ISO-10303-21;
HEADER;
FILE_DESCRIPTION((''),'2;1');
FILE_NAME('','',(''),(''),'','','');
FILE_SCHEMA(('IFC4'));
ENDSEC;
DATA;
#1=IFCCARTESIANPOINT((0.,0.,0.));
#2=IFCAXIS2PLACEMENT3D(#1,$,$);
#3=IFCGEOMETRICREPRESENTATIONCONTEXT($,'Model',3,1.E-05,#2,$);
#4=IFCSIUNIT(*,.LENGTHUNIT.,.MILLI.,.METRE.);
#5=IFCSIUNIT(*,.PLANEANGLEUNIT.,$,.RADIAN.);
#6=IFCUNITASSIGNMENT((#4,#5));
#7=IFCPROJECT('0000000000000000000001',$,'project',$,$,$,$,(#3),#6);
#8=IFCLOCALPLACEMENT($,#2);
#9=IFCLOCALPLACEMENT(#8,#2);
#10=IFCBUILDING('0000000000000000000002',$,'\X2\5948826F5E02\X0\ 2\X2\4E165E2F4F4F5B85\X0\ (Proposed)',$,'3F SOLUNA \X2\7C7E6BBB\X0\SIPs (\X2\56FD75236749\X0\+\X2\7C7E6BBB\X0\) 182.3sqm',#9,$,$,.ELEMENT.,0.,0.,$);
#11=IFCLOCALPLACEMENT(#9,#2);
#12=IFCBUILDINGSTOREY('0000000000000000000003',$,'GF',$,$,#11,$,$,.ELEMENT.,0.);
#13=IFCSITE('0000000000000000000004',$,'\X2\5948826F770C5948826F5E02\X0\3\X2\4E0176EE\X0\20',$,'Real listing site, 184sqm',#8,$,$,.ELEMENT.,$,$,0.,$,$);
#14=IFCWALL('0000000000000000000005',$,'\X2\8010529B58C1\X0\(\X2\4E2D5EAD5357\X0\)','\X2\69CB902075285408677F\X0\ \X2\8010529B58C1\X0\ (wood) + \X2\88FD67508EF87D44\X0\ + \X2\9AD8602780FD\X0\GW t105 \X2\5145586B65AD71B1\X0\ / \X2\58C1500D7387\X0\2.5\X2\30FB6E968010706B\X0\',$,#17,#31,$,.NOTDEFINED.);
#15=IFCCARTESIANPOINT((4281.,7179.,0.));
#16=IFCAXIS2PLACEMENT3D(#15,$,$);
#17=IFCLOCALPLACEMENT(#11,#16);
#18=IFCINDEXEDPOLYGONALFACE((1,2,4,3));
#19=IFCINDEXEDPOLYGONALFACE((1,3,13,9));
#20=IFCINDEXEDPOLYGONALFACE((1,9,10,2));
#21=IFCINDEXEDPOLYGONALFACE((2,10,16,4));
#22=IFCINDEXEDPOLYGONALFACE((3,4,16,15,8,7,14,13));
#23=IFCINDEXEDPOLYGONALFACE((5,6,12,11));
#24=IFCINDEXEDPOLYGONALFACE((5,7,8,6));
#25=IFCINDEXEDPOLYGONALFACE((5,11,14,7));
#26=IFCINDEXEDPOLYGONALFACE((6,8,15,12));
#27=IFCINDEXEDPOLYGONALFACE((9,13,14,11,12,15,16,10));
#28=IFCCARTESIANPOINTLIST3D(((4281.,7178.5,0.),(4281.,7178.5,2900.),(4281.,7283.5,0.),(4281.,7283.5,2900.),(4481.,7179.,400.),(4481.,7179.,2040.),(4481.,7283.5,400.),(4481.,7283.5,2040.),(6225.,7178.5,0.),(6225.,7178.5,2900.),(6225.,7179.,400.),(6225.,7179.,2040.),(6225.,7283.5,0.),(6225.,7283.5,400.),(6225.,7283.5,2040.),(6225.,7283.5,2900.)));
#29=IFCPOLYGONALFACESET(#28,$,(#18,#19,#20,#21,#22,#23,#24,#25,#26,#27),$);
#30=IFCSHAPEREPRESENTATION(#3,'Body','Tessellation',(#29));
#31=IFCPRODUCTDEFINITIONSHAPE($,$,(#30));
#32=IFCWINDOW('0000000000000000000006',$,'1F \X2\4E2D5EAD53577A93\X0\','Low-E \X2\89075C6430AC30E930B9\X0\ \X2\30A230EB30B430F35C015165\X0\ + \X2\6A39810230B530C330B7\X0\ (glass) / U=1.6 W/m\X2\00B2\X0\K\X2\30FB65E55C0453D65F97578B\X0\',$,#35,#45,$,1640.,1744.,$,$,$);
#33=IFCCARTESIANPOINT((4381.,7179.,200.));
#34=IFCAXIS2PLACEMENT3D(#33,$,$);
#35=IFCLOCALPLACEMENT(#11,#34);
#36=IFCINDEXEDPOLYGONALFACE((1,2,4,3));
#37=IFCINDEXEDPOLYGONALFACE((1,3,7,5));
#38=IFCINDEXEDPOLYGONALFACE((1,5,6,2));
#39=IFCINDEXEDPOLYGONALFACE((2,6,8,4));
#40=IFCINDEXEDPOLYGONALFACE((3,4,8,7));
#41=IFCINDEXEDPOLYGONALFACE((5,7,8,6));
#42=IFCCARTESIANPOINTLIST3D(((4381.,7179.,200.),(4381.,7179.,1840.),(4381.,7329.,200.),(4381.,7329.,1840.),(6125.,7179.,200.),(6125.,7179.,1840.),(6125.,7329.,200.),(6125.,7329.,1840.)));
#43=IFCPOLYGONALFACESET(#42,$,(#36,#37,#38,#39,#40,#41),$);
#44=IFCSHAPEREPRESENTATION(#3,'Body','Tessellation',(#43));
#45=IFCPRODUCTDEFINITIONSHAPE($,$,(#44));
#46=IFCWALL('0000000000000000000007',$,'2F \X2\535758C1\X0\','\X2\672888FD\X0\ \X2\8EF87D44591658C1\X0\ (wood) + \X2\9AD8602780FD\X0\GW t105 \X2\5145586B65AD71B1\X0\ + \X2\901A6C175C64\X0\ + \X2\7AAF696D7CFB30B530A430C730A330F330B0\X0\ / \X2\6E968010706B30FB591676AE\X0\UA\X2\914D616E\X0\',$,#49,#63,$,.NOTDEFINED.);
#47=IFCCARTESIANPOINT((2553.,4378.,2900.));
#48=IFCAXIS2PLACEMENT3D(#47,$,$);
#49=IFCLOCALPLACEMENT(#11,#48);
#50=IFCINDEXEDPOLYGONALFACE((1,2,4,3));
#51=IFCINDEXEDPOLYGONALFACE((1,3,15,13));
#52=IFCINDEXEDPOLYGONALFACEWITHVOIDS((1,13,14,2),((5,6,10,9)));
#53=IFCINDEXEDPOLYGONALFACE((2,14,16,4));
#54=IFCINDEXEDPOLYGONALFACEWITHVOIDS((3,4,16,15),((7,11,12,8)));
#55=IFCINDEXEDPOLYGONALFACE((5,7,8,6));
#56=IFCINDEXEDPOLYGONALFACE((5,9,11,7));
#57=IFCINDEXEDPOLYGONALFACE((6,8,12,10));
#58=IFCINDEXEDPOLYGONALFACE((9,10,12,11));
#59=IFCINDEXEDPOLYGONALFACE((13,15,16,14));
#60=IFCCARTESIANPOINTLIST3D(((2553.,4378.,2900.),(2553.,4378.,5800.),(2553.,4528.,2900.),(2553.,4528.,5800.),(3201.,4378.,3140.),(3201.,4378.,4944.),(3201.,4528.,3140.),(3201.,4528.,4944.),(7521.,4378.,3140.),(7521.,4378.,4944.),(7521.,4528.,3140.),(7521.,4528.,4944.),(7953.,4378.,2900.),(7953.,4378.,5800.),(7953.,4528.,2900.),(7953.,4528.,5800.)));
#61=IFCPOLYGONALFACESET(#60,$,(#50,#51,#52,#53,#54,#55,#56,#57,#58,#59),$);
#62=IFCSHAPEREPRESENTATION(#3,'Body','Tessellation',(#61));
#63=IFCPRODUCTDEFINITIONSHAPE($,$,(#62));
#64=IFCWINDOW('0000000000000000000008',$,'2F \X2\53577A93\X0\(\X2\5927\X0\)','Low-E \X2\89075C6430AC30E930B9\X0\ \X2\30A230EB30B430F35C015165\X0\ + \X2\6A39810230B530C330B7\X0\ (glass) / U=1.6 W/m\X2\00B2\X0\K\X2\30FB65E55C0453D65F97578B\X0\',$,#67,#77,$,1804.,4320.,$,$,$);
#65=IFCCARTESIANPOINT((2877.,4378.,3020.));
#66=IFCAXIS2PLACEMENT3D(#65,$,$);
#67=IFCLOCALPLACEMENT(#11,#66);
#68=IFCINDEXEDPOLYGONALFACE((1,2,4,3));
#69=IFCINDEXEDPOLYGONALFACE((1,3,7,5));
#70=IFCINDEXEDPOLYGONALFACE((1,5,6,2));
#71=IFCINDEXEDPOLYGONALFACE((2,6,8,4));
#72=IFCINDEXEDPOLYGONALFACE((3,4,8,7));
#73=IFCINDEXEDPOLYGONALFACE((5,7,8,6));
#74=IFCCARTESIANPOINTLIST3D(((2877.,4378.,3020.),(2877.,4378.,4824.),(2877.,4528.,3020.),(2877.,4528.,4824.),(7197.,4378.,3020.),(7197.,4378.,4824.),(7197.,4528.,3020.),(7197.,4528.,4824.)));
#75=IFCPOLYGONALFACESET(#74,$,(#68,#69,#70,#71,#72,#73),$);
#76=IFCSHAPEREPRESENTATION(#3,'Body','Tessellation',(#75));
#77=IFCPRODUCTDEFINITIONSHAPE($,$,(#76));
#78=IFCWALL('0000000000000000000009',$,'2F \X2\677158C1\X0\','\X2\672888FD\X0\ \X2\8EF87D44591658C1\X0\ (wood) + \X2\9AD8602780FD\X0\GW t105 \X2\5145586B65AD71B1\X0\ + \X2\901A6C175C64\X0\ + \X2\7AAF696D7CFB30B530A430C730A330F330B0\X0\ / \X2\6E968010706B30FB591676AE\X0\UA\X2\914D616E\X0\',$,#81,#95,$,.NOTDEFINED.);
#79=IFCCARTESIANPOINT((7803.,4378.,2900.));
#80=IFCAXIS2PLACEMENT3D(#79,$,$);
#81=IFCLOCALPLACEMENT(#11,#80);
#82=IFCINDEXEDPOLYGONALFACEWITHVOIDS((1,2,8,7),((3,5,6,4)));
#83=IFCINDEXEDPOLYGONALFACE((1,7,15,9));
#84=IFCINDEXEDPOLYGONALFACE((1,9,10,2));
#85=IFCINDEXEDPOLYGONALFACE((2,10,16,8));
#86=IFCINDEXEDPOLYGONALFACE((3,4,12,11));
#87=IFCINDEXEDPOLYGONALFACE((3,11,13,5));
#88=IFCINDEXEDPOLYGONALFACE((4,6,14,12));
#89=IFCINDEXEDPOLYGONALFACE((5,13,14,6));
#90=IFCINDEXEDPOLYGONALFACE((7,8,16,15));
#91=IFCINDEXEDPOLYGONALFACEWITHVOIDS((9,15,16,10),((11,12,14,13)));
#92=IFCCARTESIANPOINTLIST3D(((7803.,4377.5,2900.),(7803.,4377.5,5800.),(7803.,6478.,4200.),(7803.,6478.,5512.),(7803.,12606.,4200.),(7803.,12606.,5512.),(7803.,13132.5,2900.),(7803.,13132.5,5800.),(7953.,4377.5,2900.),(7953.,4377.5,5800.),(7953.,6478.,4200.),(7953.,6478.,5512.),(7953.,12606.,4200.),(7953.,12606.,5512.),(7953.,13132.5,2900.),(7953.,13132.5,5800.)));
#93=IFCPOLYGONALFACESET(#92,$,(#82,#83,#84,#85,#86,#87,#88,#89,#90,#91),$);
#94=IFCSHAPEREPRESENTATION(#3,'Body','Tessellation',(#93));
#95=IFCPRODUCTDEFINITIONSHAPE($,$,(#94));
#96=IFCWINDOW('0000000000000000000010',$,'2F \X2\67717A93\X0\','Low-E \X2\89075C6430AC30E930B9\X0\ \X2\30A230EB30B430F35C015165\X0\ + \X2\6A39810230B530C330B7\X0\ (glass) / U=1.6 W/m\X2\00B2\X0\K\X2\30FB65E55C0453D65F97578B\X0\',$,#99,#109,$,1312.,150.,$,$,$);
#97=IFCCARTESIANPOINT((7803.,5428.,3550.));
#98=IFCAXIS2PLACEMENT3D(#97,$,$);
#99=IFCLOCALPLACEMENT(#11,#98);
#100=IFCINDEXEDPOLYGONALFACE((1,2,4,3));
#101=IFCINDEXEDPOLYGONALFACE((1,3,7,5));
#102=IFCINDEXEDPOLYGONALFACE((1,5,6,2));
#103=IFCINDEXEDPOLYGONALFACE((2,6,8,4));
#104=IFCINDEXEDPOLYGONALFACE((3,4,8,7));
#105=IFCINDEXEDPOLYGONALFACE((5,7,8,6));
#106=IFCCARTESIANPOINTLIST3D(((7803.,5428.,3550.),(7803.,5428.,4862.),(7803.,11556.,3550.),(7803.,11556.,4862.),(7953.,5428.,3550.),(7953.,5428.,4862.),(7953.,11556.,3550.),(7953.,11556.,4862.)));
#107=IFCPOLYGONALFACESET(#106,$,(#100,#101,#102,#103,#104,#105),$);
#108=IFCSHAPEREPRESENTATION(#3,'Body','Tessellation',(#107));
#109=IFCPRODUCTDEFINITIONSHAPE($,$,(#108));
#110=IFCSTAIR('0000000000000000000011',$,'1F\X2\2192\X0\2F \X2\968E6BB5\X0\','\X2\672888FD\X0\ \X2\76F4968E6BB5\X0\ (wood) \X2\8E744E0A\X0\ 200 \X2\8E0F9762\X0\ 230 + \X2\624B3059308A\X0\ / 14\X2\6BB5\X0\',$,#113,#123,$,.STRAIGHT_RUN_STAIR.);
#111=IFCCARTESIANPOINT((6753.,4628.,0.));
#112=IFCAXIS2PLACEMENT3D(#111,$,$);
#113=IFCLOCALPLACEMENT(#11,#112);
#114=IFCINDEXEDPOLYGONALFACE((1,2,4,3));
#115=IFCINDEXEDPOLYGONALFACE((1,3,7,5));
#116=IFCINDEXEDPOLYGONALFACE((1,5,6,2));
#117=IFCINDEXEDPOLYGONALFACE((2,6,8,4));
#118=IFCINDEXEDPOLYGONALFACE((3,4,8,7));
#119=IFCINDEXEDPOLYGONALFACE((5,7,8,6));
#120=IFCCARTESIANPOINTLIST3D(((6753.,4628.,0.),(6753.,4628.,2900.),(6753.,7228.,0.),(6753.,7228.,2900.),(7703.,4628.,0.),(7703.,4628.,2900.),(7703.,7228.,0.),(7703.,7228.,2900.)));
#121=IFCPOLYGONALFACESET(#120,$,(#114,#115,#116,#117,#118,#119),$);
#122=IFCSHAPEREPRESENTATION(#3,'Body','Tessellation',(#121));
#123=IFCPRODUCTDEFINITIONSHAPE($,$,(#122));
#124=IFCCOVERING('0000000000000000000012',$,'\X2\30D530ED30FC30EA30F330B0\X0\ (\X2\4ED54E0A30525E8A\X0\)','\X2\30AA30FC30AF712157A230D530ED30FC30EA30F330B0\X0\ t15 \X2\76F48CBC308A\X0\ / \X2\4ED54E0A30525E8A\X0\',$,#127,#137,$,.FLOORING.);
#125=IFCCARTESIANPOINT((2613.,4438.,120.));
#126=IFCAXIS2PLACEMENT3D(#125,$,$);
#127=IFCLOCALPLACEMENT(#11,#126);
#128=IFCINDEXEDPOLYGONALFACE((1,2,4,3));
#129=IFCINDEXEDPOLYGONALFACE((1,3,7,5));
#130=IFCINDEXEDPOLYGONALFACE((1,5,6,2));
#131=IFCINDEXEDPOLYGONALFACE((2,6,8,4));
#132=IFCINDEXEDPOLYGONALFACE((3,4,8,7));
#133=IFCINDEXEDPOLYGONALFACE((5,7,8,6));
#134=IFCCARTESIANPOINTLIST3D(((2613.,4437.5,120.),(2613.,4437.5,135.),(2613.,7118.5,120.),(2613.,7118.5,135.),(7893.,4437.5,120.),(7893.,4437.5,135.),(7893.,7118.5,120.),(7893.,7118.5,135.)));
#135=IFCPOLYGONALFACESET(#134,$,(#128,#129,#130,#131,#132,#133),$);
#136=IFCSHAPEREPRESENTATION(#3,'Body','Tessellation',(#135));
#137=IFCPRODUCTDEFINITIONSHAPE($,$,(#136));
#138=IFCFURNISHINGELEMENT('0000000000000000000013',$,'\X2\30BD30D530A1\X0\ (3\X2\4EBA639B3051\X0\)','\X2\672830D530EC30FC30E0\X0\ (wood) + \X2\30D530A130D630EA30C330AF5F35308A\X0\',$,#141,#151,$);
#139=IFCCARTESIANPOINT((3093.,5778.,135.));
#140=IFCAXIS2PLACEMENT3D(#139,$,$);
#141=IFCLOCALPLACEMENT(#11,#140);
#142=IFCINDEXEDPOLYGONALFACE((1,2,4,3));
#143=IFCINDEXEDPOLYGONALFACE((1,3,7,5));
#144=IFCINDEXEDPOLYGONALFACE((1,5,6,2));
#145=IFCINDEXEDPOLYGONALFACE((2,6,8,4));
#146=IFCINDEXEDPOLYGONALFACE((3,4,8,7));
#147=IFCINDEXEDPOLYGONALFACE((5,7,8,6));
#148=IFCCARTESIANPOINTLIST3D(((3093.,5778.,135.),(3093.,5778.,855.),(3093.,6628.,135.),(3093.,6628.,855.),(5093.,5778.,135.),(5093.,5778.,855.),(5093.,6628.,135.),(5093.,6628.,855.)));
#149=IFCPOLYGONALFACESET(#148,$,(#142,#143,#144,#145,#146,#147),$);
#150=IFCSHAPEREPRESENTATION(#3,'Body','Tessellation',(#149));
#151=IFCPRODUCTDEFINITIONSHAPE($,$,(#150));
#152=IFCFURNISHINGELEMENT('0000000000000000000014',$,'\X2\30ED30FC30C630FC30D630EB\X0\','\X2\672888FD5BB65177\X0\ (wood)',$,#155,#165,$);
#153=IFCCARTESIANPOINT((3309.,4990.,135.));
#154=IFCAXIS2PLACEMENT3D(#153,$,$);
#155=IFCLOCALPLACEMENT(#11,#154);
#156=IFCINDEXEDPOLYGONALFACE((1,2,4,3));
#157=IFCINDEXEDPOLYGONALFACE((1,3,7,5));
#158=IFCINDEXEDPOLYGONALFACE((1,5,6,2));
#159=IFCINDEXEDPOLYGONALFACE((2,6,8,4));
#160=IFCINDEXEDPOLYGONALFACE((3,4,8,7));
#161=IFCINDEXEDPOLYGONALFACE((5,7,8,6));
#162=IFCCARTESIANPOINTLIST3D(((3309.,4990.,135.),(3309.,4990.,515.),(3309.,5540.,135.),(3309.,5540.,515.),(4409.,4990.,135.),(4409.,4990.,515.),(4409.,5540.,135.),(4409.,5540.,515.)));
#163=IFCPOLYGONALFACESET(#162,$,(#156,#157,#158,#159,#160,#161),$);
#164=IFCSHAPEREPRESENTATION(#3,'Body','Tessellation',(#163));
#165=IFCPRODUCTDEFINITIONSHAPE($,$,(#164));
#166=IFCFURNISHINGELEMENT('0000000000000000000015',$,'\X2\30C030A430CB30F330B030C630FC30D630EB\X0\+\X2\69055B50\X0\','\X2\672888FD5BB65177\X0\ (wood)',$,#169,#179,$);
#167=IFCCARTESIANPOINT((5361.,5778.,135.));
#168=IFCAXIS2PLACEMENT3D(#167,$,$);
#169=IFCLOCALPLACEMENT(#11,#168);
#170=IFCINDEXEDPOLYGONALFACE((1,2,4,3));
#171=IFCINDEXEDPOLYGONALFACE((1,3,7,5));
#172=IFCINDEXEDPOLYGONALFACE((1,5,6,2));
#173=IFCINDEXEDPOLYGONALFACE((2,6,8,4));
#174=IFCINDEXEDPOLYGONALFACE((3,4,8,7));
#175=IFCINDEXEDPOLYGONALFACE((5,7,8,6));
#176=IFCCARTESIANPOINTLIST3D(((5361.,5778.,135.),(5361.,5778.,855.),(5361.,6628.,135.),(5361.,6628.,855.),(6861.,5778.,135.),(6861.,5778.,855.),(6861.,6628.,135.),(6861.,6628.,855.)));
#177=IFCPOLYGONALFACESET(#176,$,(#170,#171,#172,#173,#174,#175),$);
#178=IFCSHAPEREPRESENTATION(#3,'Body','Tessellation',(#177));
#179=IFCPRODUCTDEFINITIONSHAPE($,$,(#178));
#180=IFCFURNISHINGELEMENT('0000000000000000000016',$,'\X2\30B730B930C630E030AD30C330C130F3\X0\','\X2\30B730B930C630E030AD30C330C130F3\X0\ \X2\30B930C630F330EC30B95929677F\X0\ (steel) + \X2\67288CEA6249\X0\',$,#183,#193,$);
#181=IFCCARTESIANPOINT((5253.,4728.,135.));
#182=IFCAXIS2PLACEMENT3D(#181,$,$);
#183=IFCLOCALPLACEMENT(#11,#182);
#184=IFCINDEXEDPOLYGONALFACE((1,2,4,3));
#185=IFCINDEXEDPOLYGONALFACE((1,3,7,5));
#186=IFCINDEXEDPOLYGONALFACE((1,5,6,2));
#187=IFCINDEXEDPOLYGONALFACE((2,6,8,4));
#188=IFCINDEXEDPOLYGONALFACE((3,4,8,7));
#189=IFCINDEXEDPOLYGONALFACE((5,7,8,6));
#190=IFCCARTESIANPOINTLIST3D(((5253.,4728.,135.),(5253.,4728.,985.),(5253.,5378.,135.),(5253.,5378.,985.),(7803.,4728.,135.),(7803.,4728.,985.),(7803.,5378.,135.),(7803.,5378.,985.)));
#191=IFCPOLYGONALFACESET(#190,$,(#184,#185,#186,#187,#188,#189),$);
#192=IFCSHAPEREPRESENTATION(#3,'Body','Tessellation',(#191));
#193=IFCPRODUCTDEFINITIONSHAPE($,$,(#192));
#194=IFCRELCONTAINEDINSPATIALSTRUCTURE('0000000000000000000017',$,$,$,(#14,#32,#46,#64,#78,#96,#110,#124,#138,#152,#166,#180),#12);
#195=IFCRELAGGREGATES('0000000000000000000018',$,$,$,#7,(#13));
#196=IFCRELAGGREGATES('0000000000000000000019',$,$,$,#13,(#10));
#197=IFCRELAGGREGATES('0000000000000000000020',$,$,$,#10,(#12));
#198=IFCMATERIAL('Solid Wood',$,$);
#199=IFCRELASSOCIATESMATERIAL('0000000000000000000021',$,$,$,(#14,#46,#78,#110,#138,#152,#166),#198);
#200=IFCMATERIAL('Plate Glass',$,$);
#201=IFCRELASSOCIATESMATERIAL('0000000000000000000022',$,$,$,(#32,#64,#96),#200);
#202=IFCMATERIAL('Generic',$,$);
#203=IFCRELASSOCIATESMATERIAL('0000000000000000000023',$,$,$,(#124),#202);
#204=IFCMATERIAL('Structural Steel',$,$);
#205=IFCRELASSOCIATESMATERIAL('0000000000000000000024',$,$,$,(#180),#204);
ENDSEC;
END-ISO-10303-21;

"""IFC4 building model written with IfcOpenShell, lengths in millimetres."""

from ifc_helpers import new_model, si_unit, frame, frame_2d, origin, place, context, project, spatial, rectangle, extrude, material, element, fill, save


model = new_model("IFC4")

# Units and contexts
model_context = context("Model", 3, precision=1e-05, world=origin())
ifc_project = project(units=[si_unit("LENGTHUNIT", "METRE", prefix="MILLI"), si_unit("PLANEANGLEUNIT", "RADIAN")], contexts=[model_context])

# Site, building, storey
site_placement = place(None, origin())
site = spatial("IfcSite", under=ifc_project, at=site_placement, Name="奈良県奈良市3丁目20", ObjectType="Real listing site, 184sqm", CompositionType="ELEMENT", RefElevation=0.0)
building_placement = place(site_placement, origin())
building = spatial("IfcBuilding", under=site, at=building_placement, Name="奈良市 2世帯住宅 (Proposed)", ObjectType="3F SOLUNA 籾殻SIPs (国産杉+籾殻) 182.3sqm", CompositionType="ELEMENT", ElevationOfRefHeight=0.0, ElevationOfTerrain=0.0)
storey_placement = place(building_placement, origin())
storey = spatial("IfcBuildingStorey", under=building, at=storey_placement, Name="GF", CompositionType="ELEMENT", Elevation=0.0)

# Shared definitions
ifc_material_1 = material(Name="Solid Wood")
ifc_material_2 = material(Name="Generic")

# Shared definitions
ifc_material_3 = material(Name="Plate Glass")

# Wall, opening, window
wall_1_placement = place(storey_placement, frame((4281.0, 7179.0, 0.0)))
wall_1 = element("IfcWall", 1, at=wall_1_placement, inside=storey, material=ifc_material_1, Name="耐力壁(中庭南)", Description="構造用合板 耐力壁 (wood) + 製材軸組 + 高性能GW t105 充填断熱 / 壁倍率2.5・準耐火", PredefinedType="NOTDEFINED", context=model_context, shape_type="SweptSolid", body=[
    extrude(rectangle(XDim=1944.0, YDim=105.0, at=frame_2d((972.0, 52.0))), frame((4281.0, 7179.0, 0.0)), (0.0, 0.0, 1.0), 2900.0),
])
opening_1_placement = place(storey_placement, frame((4381.0, 7179.0, 200.0)))
opening_1 = element("IfcOpeningElement", 2, at=opening_1_placement, cuts=wall_1, PredefinedType="NOTDEFINED", context=model_context, shape_type="SweptSolid", body=[
    extrude(rectangle(XDim=1744.0, YDim=150.0, at=frame_2d((872.0, 75.0))), frame((4381.0, 7179.0, 200.0)), (0.0, 0.0, 1.0), 1640.0),
])
window_1_placement = place(storey_placement, frame((4381.0, 7179.0, 200.0)))
window_1 = element("IfcWindow", 3, at=window_1_placement, inside=storey, material=ifc_material_3, Name="1F 中庭南窓", Description="Low-E 複層ガラス アルゴン封入 + 樹脂サッシ (glass) / U=1.6 W/m²K・日射取得型", OverallHeight=1640.0, OverallWidth=1744.0, context=model_context, shape_type="SweptSolid", body=[
    extrude(rectangle(XDim=1744.0, YDim=150.0, at=frame_2d((872.0, 75.0))), frame((4381.0, 7179.0, 200.0)), (0.0, 0.0, 1.0), 1640.0),
])
fill(opening_1, window_1)

# Walls, openings, windows
wall_2_placement = place(storey_placement, frame((2553.0, 4378.0, 2900.0)))
wall_2 = element("IfcWall", 4, at=wall_2_placement, inside=storey, material=ifc_material_1, Name="2F 南壁", Description="木製 軸組外壁 (wood) + 高性能GW t105 充填断熱 + 通気層 + 窯業系サイディング / 準耐火・外皮UA配慮", PredefinedType="NOTDEFINED", context=model_context, shape_type="SweptSolid", body=[
    extrude(rectangle(XDim=5400.0, YDim=150.0, at=frame_2d((2700.0, 75.0))), frame((2553.0, 4378.0, 2900.0)), (0.0, 0.0, 1.0), 2900.0),
])
opening_2_placement = place(storey_placement, frame((2877.0, 4378.0, 3020.0)))
opening_2 = element("IfcOpeningElement", 5, at=opening_2_placement, cuts=wall_2, PredefinedType="NOTDEFINED", context=model_context, shape_type="SweptSolid", body=[
    extrude(rectangle(XDim=4320.0, YDim=150.0, at=frame_2d((2160.0, 75.0))), frame((2877.0, 4378.0, 3020.0)), (0.0, 0.0, 1.0), 1804.0),
])
window_2_placement = place(storey_placement, frame((2877.0, 4378.0, 3020.0)))
window_2 = element("IfcWindow", 6, at=window_2_placement, inside=storey, material=ifc_material_3, Name="2F 南窓(大)", Description="Low-E 複層ガラス アルゴン封入 + 樹脂サッシ (glass) / U=1.6 W/m²K・日射取得型", OverallHeight=1804.0, OverallWidth=4320.0, context=model_context, shape_type="SweptSolid", body=[
    extrude(rectangle(XDim=4320.0, YDim=150.0, at=frame_2d((2160.0, 75.0))), frame((2877.0, 4378.0, 3020.0)), (0.0, 0.0, 1.0), 1804.0),
])
fill(opening_2, window_2)
wall_3_placement = place(storey_placement, frame((7803.0, 4378.0, 2900.0)))
wall_3 = element("IfcWall", 7, at=wall_3_placement, inside=storey, material=ifc_material_1, Name="2F 東壁", Description="木製 軸組外壁 (wood) + 高性能GW t105 充填断熱 + 通気層 + 窯業系サイディング / 準耐火・外皮UA配慮", PredefinedType="NOTDEFINED", context=model_context, shape_type="SweptSolid", body=[
    extrude(rectangle(XDim=150.0, YDim=8755.0, at=frame_2d((75.0, 4377.0))), frame((7803.0, 4378.0, 2900.0)), (0.0, 0.0, 1.0), 2900.0),
])
opening_3_placement = place(storey_placement, frame((7803.0, 5428.0, 3550.0)))
opening_3 = element("IfcOpeningElement", 8, at=opening_3_placement, cuts=wall_3, PredefinedType="NOTDEFINED", context=model_context, shape_type="SweptSolid", body=[
    extrude(rectangle(XDim=150.0, YDim=6128.0, at=frame_2d((75.0, 3064.0))), frame((7803.0, 5428.0, 3550.0)), (0.0, 0.0, 1.0), 1312.0),
])
window_3_placement = place(storey_placement, frame((7803.0, 5428.0, 3550.0)))
window_3 = element("IfcWindow", 9, at=window_3_placement, inside=storey, material=ifc_material_3, Name="2F 東窓", Description="Low-E 複層ガラス アルゴン封入 + 樹脂サッシ (glass) / U=1.6 W/m²K・日射取得型", OverallHeight=1312.0, OverallWidth=150.0, context=model_context, shape_type="SweptSolid", body=[
    extrude(rectangle(XDim=150.0, YDim=6128.0, at=frame_2d((75.0, 3064.0))), frame((7803.0, 5428.0, 3550.0)), (0.0, 0.0, 1.0), 1312.0),
])
fill(opening_3, window_3)

# Stair
stair_placement = place(storey_placement, frame((6753.0, 4628.0, 0.0)))
element("IfcStair", 10, at=stair_placement, inside=storey, material=ifc_material_1, Name="1F→2F 階段", Description="木製 直階段 (wood) 蹴上 200 踏面 230 + 手すり / 14段", PredefinedType="STRAIGHT_RUN_STAIR", context=model_context, shape_type="SweptSolid", body=[
    extrude(rectangle(XDim=950.0, YDim=2600.0, at=frame_2d((475.0, 1300.0))), frame((6753.0, 4628.0, 0.0)), (0.0, 0.0, 1.0), 2900.0),
])

# Covering
covering_placement = place(storey_placement, frame((2613.0, 4438.0, 120.0)))
element("IfcCovering", 11, at=covering_placement, inside=storey, material=ifc_material_2, Name="フローリング (仕上げ床)", Description="オーク無垢フローリング t15 直貼り / 仕上げ床", PredefinedType="FLOORING", context=model_context, shape_type="SweptSolid", body=[
    extrude(rectangle(XDim=5280.0, YDim=2681.0, at=frame_2d((2640.0, 1340.0))), frame((2613.0, 4438.0, 120.0)), (0.0, 0.0, 1.0), 15.0),
])

# Furnishing elements
furnishing_1_placement = place(storey_placement, frame((3093.0, 5778.0, 135.0)))
element("IfcFurnishingElement", 12, at=furnishing_1_placement, inside=storey, material=ifc_material_1, Name="ソファ (3人掛け)", Description="木フレーム (wood) + ファブリック張り", context=model_context, shape_type="SweptSolid", body=[
    extrude(rectangle(XDim=2000.0, YDim=850.0, at=frame_2d((1000.0, 425.0))), frame((3093.0, 5778.0, 135.0)), (0.0, 0.0, 1.0), 720.0),
])
furnishing_2_placement = place(storey_placement, frame((3309.0, 4990.0, 135.0)))
element("IfcFurnishingElement", 13, at=furnishing_2_placement, inside=storey, material=ifc_material_1, Name="ローテーブル", Description="木製家具 (wood)", context=model_context, shape_type="SweptSolid", body=[
    extrude(rectangle(XDim=1100.0, YDim=550.0, at=frame_2d((550.0, 275.0))), frame((3309.0, 4990.0, 135.0)), (0.0, 0.0, 1.0), 380.0),
])
furnishing_3_placement = place(storey_placement, frame((5361.0, 5778.0, 135.0)))
element("IfcFurnishingElement", 14, at=furnishing_3_placement, inside=storey, material=ifc_material_1, Name="ダイニングテーブル+椅子", Description="木製家具 (wood)", context=model_context, shape_type="SweptSolid", body=[
    extrude(rectangle(XDim=1500.0, YDim=850.0, at=frame_2d((750.0, 425.0))), frame((5361.0, 5778.0, 135.0)), (0.0, 0.0, 1.0), 720.0),
])
ifc_material_4 = material(Name="Structural Steel")
furnishing_4_placement = place(storey_placement, frame((5253.0, 4728.0, 135.0)))
element("IfcFurnishingElement", 15, at=furnishing_4_placement, inside=storey, material=ifc_material_4, Name="システムキッチン", Description="システムキッチン ステンレス天板 (steel) + 木質扉", context=model_context, shape_type="SweptSolid", body=[
    extrude(rectangle(XDim=2550.0, YDim=650.0, at=frame_2d((1275.0, 325.0))), frame((5253.0, 4728.0, 135.0)), (0.0, 0.0, 1.0), 850.0),
])

save(model, "model.ifc")
